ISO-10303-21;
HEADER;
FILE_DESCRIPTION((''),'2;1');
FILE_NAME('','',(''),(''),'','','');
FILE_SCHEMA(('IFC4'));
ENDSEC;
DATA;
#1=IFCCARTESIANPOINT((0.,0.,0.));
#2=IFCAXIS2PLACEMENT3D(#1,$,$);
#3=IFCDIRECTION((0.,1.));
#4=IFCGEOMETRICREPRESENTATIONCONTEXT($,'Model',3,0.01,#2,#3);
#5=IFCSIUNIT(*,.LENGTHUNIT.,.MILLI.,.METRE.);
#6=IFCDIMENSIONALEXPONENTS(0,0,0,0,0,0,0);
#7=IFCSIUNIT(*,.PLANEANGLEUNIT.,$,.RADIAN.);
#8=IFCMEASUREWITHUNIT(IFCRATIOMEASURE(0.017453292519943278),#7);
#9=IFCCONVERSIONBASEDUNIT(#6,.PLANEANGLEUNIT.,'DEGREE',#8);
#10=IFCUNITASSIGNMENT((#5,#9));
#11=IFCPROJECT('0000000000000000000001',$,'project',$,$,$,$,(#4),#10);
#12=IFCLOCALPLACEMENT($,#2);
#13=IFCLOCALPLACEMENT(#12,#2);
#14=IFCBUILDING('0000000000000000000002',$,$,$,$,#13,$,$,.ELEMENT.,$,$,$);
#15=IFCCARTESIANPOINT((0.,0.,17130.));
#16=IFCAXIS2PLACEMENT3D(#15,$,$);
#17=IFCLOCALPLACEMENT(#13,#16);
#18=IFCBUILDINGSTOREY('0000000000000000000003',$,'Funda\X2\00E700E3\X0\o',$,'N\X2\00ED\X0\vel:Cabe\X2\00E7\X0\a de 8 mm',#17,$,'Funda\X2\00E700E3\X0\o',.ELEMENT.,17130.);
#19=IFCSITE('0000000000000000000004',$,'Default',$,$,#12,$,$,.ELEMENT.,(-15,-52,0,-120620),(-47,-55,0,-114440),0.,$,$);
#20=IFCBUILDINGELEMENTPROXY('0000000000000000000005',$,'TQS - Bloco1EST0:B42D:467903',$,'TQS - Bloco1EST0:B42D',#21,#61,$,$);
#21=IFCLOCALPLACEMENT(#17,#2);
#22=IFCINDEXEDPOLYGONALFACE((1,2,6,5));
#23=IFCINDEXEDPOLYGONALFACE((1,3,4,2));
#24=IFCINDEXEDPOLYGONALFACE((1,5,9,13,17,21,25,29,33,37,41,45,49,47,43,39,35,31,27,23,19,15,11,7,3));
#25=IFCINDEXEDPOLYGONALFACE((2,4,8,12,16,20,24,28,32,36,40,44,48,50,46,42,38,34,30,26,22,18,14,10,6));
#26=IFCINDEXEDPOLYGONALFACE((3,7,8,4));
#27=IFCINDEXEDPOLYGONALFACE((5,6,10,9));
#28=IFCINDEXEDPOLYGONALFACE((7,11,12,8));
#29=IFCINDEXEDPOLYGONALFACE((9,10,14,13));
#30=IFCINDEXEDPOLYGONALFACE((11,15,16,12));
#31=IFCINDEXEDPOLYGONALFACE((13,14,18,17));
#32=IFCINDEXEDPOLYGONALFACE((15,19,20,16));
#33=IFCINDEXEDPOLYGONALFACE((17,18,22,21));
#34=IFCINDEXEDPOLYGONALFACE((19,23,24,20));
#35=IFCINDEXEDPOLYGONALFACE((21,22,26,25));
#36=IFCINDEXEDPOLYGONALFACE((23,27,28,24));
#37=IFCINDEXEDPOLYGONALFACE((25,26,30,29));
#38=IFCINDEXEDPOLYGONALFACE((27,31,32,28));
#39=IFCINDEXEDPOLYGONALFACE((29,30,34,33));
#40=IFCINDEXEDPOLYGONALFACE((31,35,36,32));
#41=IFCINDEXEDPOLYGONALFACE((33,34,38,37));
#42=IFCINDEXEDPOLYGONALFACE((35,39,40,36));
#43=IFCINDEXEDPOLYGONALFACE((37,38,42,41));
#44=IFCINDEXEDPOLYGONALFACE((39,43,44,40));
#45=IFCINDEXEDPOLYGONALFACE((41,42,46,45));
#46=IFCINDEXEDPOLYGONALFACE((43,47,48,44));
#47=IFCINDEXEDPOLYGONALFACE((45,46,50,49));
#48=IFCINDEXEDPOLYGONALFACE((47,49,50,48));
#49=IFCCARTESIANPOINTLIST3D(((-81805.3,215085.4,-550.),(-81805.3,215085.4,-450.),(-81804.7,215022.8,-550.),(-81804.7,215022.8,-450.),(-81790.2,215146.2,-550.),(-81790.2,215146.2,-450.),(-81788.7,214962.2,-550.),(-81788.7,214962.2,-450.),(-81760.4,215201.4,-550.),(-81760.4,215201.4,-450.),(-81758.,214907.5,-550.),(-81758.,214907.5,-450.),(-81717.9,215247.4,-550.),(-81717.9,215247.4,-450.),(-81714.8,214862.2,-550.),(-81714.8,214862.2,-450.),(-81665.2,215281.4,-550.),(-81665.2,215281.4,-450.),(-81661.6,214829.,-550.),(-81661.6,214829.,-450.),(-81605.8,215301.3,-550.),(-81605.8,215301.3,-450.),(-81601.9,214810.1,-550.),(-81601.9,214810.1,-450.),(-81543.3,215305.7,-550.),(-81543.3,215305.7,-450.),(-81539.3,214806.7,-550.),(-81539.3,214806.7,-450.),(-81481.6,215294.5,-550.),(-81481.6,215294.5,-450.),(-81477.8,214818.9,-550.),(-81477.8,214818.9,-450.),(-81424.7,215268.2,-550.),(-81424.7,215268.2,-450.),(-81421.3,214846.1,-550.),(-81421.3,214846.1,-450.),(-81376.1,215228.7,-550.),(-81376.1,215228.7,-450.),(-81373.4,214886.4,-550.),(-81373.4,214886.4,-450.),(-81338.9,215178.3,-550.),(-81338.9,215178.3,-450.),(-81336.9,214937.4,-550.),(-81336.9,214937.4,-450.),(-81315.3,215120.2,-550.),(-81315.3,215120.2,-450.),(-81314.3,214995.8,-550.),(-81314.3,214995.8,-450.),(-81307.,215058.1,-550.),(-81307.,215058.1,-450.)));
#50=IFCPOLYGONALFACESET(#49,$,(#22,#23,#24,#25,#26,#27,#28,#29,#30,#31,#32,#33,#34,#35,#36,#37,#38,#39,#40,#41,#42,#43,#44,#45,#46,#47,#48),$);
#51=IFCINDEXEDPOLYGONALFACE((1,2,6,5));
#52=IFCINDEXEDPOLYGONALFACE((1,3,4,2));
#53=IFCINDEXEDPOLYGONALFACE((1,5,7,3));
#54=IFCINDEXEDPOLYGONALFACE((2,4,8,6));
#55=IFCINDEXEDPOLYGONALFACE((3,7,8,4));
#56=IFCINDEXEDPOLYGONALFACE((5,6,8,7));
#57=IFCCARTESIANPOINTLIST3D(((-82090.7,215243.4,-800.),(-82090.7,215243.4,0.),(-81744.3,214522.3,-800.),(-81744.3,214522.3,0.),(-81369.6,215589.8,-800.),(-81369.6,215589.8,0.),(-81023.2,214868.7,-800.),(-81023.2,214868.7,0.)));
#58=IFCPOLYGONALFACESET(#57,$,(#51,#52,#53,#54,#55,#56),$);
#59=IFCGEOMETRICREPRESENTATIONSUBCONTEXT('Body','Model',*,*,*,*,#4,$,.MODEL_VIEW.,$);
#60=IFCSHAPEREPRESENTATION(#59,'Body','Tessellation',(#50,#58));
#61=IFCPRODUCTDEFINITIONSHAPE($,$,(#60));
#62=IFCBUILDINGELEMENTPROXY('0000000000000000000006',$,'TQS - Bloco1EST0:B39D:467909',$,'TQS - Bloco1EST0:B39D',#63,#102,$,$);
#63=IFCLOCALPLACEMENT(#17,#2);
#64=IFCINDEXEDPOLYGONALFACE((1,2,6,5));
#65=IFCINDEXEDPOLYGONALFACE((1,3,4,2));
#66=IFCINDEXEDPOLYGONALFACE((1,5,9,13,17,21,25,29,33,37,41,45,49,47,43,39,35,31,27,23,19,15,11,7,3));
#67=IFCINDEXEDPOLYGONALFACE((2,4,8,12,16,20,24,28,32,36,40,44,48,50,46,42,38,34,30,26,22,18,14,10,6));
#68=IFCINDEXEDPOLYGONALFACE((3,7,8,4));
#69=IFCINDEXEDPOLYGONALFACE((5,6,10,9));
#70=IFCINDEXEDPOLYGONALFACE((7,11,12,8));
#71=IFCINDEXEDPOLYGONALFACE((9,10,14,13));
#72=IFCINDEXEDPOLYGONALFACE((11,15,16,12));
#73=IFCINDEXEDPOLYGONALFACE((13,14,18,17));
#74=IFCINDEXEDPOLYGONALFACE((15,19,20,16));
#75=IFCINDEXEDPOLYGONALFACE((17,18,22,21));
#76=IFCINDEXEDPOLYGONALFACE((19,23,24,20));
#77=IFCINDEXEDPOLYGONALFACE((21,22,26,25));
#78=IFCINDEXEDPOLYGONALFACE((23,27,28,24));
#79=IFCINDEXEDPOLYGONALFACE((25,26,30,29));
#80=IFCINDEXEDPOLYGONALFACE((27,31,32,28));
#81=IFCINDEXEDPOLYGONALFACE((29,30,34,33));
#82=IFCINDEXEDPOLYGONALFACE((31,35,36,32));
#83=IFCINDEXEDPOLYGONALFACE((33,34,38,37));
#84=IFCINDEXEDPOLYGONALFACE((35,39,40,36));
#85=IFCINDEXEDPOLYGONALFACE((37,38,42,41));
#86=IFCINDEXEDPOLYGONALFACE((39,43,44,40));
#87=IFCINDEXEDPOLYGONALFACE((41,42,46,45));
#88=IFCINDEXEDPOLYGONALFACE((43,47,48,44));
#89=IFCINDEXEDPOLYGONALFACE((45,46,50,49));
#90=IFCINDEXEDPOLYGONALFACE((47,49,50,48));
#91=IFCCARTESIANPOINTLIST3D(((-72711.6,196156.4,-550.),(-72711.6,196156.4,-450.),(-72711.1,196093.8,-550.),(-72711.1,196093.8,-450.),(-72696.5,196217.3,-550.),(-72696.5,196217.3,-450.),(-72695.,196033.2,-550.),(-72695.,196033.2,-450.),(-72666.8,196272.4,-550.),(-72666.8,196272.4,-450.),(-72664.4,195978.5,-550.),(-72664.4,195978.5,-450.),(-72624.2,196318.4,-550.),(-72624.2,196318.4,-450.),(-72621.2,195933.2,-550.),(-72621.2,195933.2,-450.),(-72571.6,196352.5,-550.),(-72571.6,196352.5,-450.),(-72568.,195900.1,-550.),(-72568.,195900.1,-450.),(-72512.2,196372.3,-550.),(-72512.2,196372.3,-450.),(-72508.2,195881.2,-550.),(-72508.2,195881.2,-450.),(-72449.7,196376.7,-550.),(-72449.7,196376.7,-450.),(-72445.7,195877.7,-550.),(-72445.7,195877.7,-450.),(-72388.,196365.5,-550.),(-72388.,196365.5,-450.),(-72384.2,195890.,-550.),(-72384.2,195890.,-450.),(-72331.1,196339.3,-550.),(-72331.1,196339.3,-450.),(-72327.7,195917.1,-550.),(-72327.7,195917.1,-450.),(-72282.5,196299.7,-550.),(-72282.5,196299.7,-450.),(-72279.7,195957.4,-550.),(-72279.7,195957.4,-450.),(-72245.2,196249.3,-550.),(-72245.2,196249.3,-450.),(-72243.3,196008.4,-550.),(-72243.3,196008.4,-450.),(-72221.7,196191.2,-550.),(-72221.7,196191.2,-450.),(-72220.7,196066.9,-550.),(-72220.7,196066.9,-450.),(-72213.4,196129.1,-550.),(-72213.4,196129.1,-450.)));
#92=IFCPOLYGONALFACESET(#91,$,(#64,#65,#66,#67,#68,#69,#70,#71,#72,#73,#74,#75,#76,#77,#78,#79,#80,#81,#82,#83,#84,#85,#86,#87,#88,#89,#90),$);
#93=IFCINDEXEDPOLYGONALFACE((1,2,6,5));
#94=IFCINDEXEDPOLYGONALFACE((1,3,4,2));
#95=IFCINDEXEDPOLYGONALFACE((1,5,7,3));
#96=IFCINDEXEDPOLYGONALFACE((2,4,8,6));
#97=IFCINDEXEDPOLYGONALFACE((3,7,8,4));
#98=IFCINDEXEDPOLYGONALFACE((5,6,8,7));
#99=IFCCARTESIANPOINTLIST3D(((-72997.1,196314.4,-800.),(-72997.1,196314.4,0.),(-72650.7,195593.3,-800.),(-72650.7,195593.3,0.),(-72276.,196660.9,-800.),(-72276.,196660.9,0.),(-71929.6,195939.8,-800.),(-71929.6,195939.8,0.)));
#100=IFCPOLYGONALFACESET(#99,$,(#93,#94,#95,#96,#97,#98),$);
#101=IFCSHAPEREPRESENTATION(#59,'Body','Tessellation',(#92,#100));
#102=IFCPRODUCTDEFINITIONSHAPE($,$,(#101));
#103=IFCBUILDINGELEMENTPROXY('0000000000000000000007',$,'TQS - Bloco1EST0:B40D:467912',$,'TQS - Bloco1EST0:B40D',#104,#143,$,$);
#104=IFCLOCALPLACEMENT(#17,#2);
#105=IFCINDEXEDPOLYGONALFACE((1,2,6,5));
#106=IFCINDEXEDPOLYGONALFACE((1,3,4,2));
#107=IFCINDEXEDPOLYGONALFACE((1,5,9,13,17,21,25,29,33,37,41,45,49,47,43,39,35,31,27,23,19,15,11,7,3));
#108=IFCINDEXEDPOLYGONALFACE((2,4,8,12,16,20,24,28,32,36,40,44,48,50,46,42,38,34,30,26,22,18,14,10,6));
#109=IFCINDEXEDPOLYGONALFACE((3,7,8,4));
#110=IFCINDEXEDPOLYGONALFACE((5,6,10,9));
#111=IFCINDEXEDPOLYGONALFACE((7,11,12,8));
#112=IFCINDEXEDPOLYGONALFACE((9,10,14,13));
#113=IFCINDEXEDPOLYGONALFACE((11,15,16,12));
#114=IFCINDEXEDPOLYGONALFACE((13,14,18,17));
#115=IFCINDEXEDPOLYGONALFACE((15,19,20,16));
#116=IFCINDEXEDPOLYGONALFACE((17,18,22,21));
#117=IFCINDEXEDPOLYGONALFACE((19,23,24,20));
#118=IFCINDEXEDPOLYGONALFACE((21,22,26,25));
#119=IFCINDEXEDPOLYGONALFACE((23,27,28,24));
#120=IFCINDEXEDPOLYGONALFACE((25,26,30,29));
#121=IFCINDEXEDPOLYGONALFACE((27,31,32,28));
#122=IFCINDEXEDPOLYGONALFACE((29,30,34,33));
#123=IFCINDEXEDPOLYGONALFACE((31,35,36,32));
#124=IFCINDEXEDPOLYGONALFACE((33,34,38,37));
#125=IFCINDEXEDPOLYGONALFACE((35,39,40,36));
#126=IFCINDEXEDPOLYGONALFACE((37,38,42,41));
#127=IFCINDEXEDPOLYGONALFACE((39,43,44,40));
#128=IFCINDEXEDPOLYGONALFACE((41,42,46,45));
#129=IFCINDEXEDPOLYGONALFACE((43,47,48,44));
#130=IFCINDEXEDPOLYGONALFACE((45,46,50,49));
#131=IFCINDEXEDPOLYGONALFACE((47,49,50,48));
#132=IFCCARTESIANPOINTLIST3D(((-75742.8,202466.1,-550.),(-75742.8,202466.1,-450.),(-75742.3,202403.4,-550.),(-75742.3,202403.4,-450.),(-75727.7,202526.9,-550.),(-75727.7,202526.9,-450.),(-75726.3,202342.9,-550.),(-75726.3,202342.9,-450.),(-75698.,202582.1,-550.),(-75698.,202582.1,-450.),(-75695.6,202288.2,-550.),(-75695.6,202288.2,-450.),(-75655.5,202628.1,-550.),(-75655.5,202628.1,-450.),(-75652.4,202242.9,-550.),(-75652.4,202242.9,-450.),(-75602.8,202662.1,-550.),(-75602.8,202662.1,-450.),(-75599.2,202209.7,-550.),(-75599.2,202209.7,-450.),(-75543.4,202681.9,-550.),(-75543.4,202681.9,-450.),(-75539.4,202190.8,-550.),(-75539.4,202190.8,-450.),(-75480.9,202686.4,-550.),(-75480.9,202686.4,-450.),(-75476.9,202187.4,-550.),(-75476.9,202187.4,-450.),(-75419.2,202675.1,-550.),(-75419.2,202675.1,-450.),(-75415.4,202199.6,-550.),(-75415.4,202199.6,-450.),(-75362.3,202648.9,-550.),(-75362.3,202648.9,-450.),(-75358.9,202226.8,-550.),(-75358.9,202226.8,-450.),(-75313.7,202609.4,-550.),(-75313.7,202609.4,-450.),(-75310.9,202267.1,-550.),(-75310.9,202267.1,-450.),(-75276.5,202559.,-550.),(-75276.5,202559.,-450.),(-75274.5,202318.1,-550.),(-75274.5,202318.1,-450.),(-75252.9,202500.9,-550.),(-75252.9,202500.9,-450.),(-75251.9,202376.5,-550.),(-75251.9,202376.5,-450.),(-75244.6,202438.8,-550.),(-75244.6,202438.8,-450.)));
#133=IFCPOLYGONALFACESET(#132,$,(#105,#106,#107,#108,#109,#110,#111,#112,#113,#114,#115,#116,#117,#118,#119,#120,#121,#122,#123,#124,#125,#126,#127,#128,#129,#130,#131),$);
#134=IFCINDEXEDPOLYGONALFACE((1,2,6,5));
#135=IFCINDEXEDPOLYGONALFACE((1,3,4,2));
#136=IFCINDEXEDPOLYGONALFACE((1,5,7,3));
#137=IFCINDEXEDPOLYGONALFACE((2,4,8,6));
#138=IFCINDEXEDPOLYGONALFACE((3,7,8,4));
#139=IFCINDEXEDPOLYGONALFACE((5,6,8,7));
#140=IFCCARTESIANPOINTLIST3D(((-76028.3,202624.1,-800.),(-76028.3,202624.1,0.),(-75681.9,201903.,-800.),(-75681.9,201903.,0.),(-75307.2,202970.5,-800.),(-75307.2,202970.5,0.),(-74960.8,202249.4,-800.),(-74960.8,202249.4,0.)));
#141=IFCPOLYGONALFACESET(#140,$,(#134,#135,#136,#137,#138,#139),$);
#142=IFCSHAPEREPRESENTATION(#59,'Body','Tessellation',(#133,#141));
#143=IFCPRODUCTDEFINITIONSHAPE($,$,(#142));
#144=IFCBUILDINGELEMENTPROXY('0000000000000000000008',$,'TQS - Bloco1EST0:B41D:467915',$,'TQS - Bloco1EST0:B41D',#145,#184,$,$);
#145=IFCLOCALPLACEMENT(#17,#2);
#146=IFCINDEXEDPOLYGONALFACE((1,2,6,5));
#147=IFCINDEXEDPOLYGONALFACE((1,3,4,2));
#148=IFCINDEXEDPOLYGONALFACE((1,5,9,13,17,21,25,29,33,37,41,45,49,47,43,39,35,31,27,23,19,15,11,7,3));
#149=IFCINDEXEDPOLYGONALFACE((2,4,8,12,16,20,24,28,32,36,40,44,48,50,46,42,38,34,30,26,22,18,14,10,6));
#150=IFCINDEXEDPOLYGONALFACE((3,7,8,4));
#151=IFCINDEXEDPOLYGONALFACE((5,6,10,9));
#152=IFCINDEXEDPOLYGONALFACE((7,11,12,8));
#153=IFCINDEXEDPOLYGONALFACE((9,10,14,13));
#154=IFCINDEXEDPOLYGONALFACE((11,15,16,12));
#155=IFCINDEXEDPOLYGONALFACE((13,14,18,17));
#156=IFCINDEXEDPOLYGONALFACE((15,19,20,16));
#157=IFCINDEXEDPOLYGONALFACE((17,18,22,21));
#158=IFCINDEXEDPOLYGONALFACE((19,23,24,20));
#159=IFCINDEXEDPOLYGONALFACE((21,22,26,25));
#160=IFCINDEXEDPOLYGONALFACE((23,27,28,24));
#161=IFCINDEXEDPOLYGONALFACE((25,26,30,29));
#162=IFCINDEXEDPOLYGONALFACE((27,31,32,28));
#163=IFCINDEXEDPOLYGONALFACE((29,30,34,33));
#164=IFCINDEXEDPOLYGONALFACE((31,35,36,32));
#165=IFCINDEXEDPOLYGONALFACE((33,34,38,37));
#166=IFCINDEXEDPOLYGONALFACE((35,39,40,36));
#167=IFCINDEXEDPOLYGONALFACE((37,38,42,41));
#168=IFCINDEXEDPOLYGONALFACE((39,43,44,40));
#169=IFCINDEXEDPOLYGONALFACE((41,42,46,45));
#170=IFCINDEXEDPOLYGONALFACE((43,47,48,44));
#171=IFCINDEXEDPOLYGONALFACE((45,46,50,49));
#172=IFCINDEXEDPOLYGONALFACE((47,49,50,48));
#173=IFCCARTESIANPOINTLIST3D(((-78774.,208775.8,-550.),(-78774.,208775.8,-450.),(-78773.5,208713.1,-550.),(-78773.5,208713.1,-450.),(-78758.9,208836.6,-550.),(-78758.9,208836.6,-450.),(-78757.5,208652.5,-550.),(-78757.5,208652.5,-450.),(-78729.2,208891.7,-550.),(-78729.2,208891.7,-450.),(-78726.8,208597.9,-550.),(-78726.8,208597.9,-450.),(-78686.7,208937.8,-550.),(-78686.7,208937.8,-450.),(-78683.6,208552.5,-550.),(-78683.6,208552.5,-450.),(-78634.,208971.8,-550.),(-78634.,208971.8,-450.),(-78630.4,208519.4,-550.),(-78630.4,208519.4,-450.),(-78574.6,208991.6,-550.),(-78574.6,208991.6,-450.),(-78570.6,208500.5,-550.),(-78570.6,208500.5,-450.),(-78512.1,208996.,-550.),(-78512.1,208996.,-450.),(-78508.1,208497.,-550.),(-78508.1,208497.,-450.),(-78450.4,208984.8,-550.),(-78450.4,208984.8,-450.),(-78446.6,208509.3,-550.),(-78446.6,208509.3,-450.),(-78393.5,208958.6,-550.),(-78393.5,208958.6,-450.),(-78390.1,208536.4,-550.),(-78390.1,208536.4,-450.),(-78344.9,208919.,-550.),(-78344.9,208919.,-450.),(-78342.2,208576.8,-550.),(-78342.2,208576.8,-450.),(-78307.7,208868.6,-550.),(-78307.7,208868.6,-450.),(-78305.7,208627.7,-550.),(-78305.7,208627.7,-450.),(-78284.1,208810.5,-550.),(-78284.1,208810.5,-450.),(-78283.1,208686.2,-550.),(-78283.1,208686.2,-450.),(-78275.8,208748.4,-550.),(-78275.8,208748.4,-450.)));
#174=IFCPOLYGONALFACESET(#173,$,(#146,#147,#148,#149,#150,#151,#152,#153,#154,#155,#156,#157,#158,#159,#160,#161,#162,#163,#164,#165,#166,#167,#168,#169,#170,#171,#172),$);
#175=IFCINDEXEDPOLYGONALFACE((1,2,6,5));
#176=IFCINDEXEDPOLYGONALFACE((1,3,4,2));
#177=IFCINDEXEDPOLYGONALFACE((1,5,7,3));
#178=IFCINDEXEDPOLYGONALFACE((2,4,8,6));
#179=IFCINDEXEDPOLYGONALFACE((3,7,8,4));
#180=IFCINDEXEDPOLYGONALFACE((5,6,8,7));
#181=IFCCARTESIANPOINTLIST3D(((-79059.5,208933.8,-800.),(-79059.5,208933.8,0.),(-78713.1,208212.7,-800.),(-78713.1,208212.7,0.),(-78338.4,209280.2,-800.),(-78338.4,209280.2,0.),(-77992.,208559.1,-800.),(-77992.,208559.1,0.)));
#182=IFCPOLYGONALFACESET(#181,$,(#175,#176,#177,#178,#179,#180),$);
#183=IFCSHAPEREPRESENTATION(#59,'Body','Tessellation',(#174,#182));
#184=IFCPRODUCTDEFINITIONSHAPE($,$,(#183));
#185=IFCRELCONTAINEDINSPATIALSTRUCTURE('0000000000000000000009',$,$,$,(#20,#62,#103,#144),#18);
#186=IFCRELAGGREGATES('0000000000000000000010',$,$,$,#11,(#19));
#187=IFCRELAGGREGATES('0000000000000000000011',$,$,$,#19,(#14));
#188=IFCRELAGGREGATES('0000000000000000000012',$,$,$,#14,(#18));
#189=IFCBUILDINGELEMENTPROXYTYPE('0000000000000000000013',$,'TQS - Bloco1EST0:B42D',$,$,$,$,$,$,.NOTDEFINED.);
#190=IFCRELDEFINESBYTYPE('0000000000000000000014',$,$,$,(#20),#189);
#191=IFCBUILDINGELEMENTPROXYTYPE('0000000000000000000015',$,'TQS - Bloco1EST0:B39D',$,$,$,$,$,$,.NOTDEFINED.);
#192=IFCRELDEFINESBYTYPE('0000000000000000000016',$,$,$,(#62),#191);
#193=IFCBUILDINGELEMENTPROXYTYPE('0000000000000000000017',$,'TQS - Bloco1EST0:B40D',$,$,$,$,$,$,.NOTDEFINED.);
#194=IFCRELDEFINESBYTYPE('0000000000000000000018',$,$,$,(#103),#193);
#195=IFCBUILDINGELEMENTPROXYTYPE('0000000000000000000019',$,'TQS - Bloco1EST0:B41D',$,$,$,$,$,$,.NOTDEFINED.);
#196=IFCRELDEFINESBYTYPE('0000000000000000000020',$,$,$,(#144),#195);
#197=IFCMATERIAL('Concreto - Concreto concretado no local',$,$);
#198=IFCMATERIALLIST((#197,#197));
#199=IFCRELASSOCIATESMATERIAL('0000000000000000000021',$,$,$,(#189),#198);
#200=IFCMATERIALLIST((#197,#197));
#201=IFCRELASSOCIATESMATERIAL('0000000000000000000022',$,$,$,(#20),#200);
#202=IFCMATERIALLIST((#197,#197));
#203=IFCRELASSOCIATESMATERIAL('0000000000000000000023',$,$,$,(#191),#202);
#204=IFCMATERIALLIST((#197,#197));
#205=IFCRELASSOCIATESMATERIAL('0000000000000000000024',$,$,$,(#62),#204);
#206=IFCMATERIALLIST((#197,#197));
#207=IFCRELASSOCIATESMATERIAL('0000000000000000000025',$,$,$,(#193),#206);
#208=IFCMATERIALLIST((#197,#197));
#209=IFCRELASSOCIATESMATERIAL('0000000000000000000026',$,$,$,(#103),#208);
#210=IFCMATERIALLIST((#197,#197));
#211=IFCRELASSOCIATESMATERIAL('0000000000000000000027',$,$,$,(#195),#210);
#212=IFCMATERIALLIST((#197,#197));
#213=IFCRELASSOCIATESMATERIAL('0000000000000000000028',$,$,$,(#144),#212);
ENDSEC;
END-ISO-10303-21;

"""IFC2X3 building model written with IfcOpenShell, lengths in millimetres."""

from ifc_helpers import new_model, entity, si_unit, converted_unit, direction, frame, frame_2d, origin, origin_2d_with_axis, place, context, subcontext, project, spatial, rectangle, circle, extrude, source, transform, mapped, material, material_list, type_object, type_shapes, element, save


model = new_model("IFC2X3")

# Units and contexts
model_context = context("Model", 3, precision=0.01, world=origin(), true_north=direction((0.0, 1.0)))
body_context = subcontext(model_context, "Body", "Model", "MODEL_VIEW")
ifc_project = project(units=[si_unit("LENGTHUNIT", "METRE", prefix="MILLI"), converted_unit("PLANEANGLEUNIT", "DEGREE", entity("IfcRatioMeasure", 0.017453292519943278), si_unit("PLANEANGLEUNIT", "RADIAN"), dimensions=[0, 0, 0, 0, 0, 0, 0])], contexts=[model_context])

# Site, building, storey
site_placement = place(None, origin())
site = spatial("IfcSite", under=ifc_project, at=site_placement, Name="Default", CompositionType="ELEMENT", RefLatitude=(-15, -52, 0, -120620), RefLongitude=(-47, -55, 0, -114440), RefElevation=0.0)
building_placement = place(site_placement, origin())
building = spatial("IfcBuilding", under=site, at=building_placement, CompositionType="ELEMENT")
storey_placement = place(building_placement, frame((0.0, 0.0, 17130.0)))
storey = spatial("IfcBuildingStorey", under=building, at=storey_placement, Name="Fundação", ObjectType="Nível:Cabeça de 8 mm", LongName="Fundação", CompositionType="ELEMENT", Elevation=17130.0)

# Building element proxies
ifc_material_1 = material(Name="Concreto - Concreto concretado no local")
ifc_material_list_1 = material_list([ifc_material_1, ifc_material_1])
ifc_material_list_2 = material_list([ifc_material_1, ifc_material_1])
building_element_proxy_type_1 = type_object("IfcBuildingElementProxyType", Name="TQS - Bloco1EST0:B42D", PredefinedType="NOTDEFINED", material=ifc_material_list_2)
shared_shape_1 = source(origin(), body_context, "Body", "SweptSolid", [
    extrude(circle(Radius=250.0, at=frame_2d((0.0, 0.0), x_axis=(1.0, 0.0))), frame((0.0, 0.0, -550.0)), (0.0, 0.0, 1.0), 100.0),
    extrude(rectangle(XDim=800.0, YDim=800.0, at=origin_2d_with_axis()), frame((0.0, 0.0, -800.0), z_axis=(0.0, 0.0, 1.0), x_axis=(-1.0, 0.0, 0.0)), (0.0, 0.0, 1.0), 800.0),
])
type_shapes(building_element_proxy_type_1, [shared_shape_1])
proxy_1_placement = place(storey_placement, frame((-81557.0, 215056.1, 0.0), z_axis=(0.0, 0.0, 1.0), x_axis=(-0.43303, 0.90138, 0.0)))
element("IfcBuildingElementProxy", 1, at=proxy_1_placement, inside=storey, type_object=building_element_proxy_type_1, material=ifc_material_list_1, Name="TQS - Bloco1EST0:B42D:467903", ObjectType="TQS - Bloco1EST0:B42D", context=body_context, shape_type="MappedRepresentation", body=[
    mapped(shared_shape_1, transform((0.0, 0.0, 0.0), scale=1.0)),
])
ifc_material_list_3 = material_list([ifc_material_1, ifc_material_1])
ifc_material_list_4 = material_list([ifc_material_1, ifc_material_1])
building_element_proxy_type_2 = type_object("IfcBuildingElementProxyType", Name="TQS - Bloco1EST0:B39D", PredefinedType="NOTDEFINED", material=ifc_material_list_4)
shared_shape_2 = source(origin(), body_context, "Body", "SweptSolid", [
    extrude(circle(Radius=250.0, at=frame_2d((0.0, 0.0), x_axis=(1.0, 0.0))), frame((0.0, 0.0, -550.0)), (0.0, 0.0, 1.0), 100.0),
    extrude(rectangle(XDim=800.0, YDim=800.0, at=origin_2d_with_axis()), frame((0.0, 0.0, -800.0), z_axis=(0.0, 0.0, 1.0), x_axis=(-1.0, 0.0, 0.0)), (0.0, 0.0, 1.0), 800.0),
])
type_shapes(building_element_proxy_type_2, [shared_shape_2])
proxy_2_placement = place(storey_placement, frame((-72463.4, 196127.1, 0.0), z_axis=(0.0, 0.0, 1.0), x_axis=(-0.43303, 0.90138, 0.0)))
element("IfcBuildingElementProxy", 2, at=proxy_2_placement, inside=storey, type_object=building_element_proxy_type_2, material=ifc_material_list_3, Name="TQS - Bloco1EST0:B39D:467909", ObjectType="TQS - Bloco1EST0:B39D", context=body_context, shape_type="MappedRepresentation", body=[
    mapped(shared_shape_2, transform((0.0, 0.0, 0.0), scale=1.0)),
])
ifc_material_list_5 = material_list([ifc_material_1, ifc_material_1])
ifc_material_list_6 = material_list([ifc_material_1, ifc_material_1])
building_element_proxy_type_3 = type_object("IfcBuildingElementProxyType", Name="TQS - Bloco1EST0:B40D", PredefinedType="NOTDEFINED", material=ifc_material_list_6)
shared_shape_3 = source(origin(), body_context, "Body", "SweptSolid", [
    extrude(circle(Radius=250.0, at=frame_2d((0.0, 0.0), x_axis=(1.0, 0.0))), frame((0.0, 0.0, -550.0)), (0.0, 0.0, 1.0), 100.0),
    extrude(rectangle(XDim=800.0, YDim=800.0, at=origin_2d_with_axis()), frame((0.0, 0.0, -800.0), z_axis=(0.0, 0.0, 1.0), x_axis=(-1.0, 0.0, 0.0)), (0.0, 0.0, 1.0), 800.0),
])
type_shapes(building_element_proxy_type_3, [shared_shape_3])
proxy_3_placement = place(storey_placement, frame((-75494.6, 202436.8, 0.0), z_axis=(0.0, 0.0, 1.0), x_axis=(-0.43303, 0.90138, 0.0)))
element("IfcBuildingElementProxy", 3, at=proxy_3_placement, inside=storey, type_object=building_element_proxy_type_3, material=ifc_material_list_5, Name="TQS - Bloco1EST0:B40D:467912", ObjectType="TQS - Bloco1EST0:B40D", context=body_context, shape_type="MappedRepresentation", body=[
    mapped(shared_shape_3, transform((0.0, 0.0, 0.0), scale=1.0)),
])
ifc_material_list_7 = material_list([ifc_material_1, ifc_material_1])
ifc_material_list_8 = material_list([ifc_material_1, ifc_material_1])
building_element_proxy_type_4 = type_object("IfcBuildingElementProxyType", Name="TQS - Bloco1EST0:B41D", PredefinedType="NOTDEFINED", material=ifc_material_list_8)
shared_shape_4 = source(origin(), body_context, "Body", "SweptSolid", [
    extrude(circle(Radius=250.0, at=frame_2d((0.0, 0.0), x_axis=(1.0, 0.0))), frame((0.0, 0.0, -550.0)), (0.0, 0.0, 1.0), 100.0),
    extrude(rectangle(XDim=800.0, YDim=800.0, at=origin_2d_with_axis()), frame((0.0, 0.0, -800.0), z_axis=(0.0, 0.0, 1.0), x_axis=(-1.0, 0.0, 0.0)), (0.0, 0.0, 1.0), 800.0),
])
type_shapes(building_element_proxy_type_4, [shared_shape_4])
proxy_4_placement = place(storey_placement, frame((-78525.8, 208746.4, 0.0), z_axis=(0.0, 0.0, 1.0), x_axis=(-0.43303, 0.90138, 0.0)))
element("IfcBuildingElementProxy", 4, at=proxy_4_placement, inside=storey, type_object=building_element_proxy_type_4, material=ifc_material_list_7, Name="TQS - Bloco1EST0:B41D:467915", ObjectType="TQS - Bloco1EST0:B41D", context=body_context, shape_type="MappedRepresentation", body=[
    mapped(shared_shape_4, transform((0.0, 0.0, 0.0), scale=1.0)),
])

save(model, "model.ifc")
